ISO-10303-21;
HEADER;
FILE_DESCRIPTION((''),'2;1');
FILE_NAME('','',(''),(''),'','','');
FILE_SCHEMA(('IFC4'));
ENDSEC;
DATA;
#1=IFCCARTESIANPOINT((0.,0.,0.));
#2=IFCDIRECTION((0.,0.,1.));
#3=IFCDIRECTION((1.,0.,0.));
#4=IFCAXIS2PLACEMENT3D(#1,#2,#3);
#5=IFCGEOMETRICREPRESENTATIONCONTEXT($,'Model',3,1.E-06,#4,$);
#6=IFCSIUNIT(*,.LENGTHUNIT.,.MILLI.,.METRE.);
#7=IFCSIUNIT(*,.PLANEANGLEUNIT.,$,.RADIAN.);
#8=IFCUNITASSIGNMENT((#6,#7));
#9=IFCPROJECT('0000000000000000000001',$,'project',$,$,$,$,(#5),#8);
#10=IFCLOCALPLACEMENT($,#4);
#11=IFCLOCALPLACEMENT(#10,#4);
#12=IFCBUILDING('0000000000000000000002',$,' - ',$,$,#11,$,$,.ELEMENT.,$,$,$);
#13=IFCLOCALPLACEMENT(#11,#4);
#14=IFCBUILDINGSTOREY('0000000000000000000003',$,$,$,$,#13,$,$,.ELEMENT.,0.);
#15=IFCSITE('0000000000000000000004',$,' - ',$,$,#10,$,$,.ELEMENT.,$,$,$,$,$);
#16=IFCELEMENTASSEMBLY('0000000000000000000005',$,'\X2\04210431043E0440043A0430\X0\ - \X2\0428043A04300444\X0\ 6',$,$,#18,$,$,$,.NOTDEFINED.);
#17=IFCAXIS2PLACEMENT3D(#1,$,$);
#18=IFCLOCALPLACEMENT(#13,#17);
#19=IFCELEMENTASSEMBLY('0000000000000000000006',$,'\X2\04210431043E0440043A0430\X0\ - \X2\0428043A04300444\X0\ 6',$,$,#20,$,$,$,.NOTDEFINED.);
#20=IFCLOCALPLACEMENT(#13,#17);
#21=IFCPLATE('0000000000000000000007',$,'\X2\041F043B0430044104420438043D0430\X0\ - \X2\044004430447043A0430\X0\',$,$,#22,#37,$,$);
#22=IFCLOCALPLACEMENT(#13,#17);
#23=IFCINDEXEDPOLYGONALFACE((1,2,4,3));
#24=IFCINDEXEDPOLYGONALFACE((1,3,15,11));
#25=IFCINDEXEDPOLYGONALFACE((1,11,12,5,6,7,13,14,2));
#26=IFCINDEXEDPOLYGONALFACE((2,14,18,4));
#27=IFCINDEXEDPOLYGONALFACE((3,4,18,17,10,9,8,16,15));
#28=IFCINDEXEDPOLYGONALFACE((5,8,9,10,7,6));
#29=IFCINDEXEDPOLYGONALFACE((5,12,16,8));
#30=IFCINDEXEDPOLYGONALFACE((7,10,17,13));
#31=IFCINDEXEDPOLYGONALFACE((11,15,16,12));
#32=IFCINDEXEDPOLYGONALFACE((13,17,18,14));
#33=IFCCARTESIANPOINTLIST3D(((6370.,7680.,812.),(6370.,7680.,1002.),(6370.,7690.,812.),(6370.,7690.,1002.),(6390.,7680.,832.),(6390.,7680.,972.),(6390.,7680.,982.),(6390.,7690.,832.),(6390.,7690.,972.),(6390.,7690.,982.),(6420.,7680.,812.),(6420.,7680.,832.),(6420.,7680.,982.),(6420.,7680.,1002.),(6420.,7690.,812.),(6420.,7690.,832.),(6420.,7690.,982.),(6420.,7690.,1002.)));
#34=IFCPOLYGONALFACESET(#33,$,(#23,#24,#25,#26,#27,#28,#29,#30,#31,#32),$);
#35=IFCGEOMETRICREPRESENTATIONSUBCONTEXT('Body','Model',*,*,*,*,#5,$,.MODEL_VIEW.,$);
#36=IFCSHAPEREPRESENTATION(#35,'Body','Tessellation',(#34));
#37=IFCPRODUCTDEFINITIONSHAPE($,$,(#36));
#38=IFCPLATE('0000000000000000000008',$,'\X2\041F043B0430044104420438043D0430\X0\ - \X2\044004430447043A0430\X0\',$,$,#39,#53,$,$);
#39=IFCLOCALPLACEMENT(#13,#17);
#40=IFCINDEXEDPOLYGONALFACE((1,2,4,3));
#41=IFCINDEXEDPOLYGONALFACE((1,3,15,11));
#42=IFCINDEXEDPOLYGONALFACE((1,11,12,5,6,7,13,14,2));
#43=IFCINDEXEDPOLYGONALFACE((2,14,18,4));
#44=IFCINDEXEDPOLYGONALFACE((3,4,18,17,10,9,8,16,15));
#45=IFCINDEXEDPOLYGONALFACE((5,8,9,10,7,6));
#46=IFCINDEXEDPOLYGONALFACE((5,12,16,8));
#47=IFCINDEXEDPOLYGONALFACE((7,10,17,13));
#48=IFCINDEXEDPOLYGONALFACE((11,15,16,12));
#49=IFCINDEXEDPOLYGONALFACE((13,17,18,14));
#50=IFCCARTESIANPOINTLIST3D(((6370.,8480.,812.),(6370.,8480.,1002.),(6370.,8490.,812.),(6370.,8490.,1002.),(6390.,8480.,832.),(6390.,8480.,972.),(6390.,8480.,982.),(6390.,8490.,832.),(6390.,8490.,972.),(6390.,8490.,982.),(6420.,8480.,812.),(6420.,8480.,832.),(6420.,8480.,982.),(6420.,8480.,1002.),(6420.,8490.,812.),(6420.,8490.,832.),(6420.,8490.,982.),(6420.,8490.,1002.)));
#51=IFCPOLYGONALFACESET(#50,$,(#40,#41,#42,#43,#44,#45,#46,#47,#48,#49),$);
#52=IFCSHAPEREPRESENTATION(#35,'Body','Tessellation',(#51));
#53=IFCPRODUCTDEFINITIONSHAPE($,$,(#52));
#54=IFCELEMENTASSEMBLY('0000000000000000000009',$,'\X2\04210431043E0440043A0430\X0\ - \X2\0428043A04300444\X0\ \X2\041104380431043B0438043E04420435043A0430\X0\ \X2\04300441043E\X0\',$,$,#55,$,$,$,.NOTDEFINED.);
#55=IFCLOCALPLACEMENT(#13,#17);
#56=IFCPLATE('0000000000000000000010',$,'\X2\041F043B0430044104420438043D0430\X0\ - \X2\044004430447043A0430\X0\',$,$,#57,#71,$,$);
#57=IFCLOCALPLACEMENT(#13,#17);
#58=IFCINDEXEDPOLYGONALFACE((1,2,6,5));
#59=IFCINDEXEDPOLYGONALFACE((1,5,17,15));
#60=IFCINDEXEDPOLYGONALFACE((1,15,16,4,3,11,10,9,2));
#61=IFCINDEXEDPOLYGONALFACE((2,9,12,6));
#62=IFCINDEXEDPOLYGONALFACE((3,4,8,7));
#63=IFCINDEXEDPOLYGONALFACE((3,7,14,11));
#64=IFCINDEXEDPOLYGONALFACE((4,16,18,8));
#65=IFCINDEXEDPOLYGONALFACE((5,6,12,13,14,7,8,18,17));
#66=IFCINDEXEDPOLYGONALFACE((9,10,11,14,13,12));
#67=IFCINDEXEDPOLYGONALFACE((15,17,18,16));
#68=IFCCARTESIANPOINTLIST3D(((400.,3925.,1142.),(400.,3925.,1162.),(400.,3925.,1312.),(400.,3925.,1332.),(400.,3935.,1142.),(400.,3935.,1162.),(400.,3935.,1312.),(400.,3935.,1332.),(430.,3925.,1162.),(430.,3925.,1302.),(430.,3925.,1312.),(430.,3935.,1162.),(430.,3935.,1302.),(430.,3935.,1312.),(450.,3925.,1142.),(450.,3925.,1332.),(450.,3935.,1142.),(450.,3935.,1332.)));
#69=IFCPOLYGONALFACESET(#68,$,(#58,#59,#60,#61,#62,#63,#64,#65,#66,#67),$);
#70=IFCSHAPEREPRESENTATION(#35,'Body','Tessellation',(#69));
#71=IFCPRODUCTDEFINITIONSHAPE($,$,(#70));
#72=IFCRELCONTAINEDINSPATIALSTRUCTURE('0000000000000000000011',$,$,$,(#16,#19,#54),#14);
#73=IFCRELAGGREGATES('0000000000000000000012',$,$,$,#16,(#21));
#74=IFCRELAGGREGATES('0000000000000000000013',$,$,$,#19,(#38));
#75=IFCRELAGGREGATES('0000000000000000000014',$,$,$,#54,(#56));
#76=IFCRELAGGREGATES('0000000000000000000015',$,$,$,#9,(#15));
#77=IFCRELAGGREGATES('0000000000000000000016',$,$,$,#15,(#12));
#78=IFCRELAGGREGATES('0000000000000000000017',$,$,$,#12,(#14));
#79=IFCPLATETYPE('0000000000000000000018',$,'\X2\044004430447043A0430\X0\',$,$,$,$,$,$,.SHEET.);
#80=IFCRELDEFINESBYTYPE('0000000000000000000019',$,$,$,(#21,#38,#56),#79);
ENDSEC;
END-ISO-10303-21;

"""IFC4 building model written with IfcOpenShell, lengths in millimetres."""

from ifc_helpers import new_model, si_unit, frame, origin_with_axes, place, context, subcontext, project, spatial, line, indexed_curve, outline, extrude, source, transform, mapped, type_object, element, aggregate, save


model = new_model("IFC4")

# Units and contexts
model_context = context("Model", 3, precision=1e-06, world=origin_with_axes())
body_context = subcontext(model_context, "Body", "Model", "MODEL_VIEW")
ifc_project = project(units=[si_unit("LENGTHUNIT", "METRE", prefix="MILLI"), si_unit("PLANEANGLEUNIT", "RADIAN")], contexts=[model_context])

# Site, building, storey
site_placement = place(None, origin_with_axes())
site = spatial("IfcSite", under=ifc_project, at=site_placement, Name=" - ", CompositionType="ELEMENT")
building_placement = place(site_placement, origin_with_axes())
building = spatial("IfcBuilding", under=site, at=building_placement, Name=" - ", CompositionType="ELEMENT")
storey_placement = place(building_placement, origin_with_axes())
storey = spatial("IfcBuildingStorey", under=building, at=storey_placement, CompositionType="ELEMENT", Elevation=0.0)

# Shared definitions
plate_type = type_object("IfcPlateType", Name="ручка", PredefinedType="SHEET")

# Element assemblies
assembly_1_placement = place(storey_placement, frame((6420.0, 8050.0, 2.0), z_axis=(0.0, 0.0, 1.0), x_axis=(0.0, -1.0, 0.0)))
assembly_1 = element("IfcElementAssembly", 1, at=assembly_1_placement, inside=storey, Name="Сборка - Шкаф 6", PredefinedType="NOTDEFINED")
assembly_2_placement = place(storey_placement, frame((6420.0, 8850.0, 2.0), z_axis=(0.0, 0.0, 1.0), x_axis=(0.0, -1.0, 0.0)))
assembly_2 = element("IfcElementAssembly", 2, at=assembly_2_placement, inside=storey, Name="Сборка - Шкаф 6", PredefinedType="NOTDEFINED")

# Plates
shared_shape_1 = source(origin_with_axes(), body_context, "Body", "SweptSolid", [
    extrude(outline(indexed_curve([(-95.0, -25.0), (-75.0, -25.0), (-75.0, 5.0), (-65.0, 5.0), (75.0, 5.0), (75.0, -25.0), (95.0, -25.0), (95.0, 25.0), (-95.0, 25.0)], segments=[line(1, 2), line(2, 3), line(3, 4), line(4, 5), line(5, 6), line(6, 7), line(7, 8), line(8, 9), line(9, 1)])), origin_with_axes(), (0.0, 0.0, 1.0), 10.0),
])
plate_1_placement = place(assembly_1_placement, frame((370.0, -25.0, 905.0), z_axis=(-1.0, 0.0, 0.0), x_axis=(0.0, 0.0, -1.0)))
plate_1 = element("IfcPlate", 3, at=plate_1_placement, type_object=plate_type, Name="Пластина - ручка", context=body_context, shape_type="MappedRepresentation", body=[
    mapped(shared_shape_1, transform((0.0, 0.0, 0.0), x_axis=(1.0, 0.0, 0.0), y_axis=(0.0, 1.0, 0.0), z_axis=(0.0, 0.0, 1.0), scale=1.0)),
])
aggregate(assembly_1, [plate_1])
plate_2_placement = place(assembly_2_placement, frame((370.0, -25.0, 905.0), z_axis=(-1.0, 0.0, 0.0), x_axis=(0.0, 0.0, -1.0)))
plate_2 = element("IfcPlate", 4, at=plate_2_placement, type_object=plate_type, Name="Пластина - ручка", context=body_context, shape_type="MappedRepresentation", body=[
    mapped(shared_shape_1, transform((0.0, 0.0, 0.0), x_axis=(1.0, 0.0, 0.0), y_axis=(0.0, 1.0, 0.0), z_axis=(0.0, 0.0, 1.0), scale=1.0)),
])
aggregate(assembly_2, [plate_2])

# Element assembly, plate
assembly_3_placement = place(storey_placement, frame((400.0, 2580.0, 2.0), z_axis=(0.0, 0.0, 1.0), x_axis=(0.0, 1.0, 0.0)))
assembly_3 = element("IfcElementAssembly", 5, at=assembly_3_placement, inside=storey, Name="Сборка - Шкаф Библиотека асо", PredefinedType="NOTDEFINED")
plate_3_placement = place(assembly_3_placement, frame((1355.0, -25.0, 1235.0), z_axis=(-1.0, 0.0, 0.0), x_axis=(0.0, 0.0, -1.0)))
plate_3 = element("IfcPlate", 6, at=plate_3_placement, type_object=plate_type, Name="Пластина - ручка", context=body_context, shape_type="MappedRepresentation", body=[
    mapped(shared_shape_1, transform((0.0, 0.0, 0.0), x_axis=(1.0, 0.0, 0.0), y_axis=(0.0, 1.0, 0.0), z_axis=(0.0, 0.0, 1.0), scale=1.0)),
])
aggregate(assembly_3, [plate_3])

save(model, "model.ifc")
